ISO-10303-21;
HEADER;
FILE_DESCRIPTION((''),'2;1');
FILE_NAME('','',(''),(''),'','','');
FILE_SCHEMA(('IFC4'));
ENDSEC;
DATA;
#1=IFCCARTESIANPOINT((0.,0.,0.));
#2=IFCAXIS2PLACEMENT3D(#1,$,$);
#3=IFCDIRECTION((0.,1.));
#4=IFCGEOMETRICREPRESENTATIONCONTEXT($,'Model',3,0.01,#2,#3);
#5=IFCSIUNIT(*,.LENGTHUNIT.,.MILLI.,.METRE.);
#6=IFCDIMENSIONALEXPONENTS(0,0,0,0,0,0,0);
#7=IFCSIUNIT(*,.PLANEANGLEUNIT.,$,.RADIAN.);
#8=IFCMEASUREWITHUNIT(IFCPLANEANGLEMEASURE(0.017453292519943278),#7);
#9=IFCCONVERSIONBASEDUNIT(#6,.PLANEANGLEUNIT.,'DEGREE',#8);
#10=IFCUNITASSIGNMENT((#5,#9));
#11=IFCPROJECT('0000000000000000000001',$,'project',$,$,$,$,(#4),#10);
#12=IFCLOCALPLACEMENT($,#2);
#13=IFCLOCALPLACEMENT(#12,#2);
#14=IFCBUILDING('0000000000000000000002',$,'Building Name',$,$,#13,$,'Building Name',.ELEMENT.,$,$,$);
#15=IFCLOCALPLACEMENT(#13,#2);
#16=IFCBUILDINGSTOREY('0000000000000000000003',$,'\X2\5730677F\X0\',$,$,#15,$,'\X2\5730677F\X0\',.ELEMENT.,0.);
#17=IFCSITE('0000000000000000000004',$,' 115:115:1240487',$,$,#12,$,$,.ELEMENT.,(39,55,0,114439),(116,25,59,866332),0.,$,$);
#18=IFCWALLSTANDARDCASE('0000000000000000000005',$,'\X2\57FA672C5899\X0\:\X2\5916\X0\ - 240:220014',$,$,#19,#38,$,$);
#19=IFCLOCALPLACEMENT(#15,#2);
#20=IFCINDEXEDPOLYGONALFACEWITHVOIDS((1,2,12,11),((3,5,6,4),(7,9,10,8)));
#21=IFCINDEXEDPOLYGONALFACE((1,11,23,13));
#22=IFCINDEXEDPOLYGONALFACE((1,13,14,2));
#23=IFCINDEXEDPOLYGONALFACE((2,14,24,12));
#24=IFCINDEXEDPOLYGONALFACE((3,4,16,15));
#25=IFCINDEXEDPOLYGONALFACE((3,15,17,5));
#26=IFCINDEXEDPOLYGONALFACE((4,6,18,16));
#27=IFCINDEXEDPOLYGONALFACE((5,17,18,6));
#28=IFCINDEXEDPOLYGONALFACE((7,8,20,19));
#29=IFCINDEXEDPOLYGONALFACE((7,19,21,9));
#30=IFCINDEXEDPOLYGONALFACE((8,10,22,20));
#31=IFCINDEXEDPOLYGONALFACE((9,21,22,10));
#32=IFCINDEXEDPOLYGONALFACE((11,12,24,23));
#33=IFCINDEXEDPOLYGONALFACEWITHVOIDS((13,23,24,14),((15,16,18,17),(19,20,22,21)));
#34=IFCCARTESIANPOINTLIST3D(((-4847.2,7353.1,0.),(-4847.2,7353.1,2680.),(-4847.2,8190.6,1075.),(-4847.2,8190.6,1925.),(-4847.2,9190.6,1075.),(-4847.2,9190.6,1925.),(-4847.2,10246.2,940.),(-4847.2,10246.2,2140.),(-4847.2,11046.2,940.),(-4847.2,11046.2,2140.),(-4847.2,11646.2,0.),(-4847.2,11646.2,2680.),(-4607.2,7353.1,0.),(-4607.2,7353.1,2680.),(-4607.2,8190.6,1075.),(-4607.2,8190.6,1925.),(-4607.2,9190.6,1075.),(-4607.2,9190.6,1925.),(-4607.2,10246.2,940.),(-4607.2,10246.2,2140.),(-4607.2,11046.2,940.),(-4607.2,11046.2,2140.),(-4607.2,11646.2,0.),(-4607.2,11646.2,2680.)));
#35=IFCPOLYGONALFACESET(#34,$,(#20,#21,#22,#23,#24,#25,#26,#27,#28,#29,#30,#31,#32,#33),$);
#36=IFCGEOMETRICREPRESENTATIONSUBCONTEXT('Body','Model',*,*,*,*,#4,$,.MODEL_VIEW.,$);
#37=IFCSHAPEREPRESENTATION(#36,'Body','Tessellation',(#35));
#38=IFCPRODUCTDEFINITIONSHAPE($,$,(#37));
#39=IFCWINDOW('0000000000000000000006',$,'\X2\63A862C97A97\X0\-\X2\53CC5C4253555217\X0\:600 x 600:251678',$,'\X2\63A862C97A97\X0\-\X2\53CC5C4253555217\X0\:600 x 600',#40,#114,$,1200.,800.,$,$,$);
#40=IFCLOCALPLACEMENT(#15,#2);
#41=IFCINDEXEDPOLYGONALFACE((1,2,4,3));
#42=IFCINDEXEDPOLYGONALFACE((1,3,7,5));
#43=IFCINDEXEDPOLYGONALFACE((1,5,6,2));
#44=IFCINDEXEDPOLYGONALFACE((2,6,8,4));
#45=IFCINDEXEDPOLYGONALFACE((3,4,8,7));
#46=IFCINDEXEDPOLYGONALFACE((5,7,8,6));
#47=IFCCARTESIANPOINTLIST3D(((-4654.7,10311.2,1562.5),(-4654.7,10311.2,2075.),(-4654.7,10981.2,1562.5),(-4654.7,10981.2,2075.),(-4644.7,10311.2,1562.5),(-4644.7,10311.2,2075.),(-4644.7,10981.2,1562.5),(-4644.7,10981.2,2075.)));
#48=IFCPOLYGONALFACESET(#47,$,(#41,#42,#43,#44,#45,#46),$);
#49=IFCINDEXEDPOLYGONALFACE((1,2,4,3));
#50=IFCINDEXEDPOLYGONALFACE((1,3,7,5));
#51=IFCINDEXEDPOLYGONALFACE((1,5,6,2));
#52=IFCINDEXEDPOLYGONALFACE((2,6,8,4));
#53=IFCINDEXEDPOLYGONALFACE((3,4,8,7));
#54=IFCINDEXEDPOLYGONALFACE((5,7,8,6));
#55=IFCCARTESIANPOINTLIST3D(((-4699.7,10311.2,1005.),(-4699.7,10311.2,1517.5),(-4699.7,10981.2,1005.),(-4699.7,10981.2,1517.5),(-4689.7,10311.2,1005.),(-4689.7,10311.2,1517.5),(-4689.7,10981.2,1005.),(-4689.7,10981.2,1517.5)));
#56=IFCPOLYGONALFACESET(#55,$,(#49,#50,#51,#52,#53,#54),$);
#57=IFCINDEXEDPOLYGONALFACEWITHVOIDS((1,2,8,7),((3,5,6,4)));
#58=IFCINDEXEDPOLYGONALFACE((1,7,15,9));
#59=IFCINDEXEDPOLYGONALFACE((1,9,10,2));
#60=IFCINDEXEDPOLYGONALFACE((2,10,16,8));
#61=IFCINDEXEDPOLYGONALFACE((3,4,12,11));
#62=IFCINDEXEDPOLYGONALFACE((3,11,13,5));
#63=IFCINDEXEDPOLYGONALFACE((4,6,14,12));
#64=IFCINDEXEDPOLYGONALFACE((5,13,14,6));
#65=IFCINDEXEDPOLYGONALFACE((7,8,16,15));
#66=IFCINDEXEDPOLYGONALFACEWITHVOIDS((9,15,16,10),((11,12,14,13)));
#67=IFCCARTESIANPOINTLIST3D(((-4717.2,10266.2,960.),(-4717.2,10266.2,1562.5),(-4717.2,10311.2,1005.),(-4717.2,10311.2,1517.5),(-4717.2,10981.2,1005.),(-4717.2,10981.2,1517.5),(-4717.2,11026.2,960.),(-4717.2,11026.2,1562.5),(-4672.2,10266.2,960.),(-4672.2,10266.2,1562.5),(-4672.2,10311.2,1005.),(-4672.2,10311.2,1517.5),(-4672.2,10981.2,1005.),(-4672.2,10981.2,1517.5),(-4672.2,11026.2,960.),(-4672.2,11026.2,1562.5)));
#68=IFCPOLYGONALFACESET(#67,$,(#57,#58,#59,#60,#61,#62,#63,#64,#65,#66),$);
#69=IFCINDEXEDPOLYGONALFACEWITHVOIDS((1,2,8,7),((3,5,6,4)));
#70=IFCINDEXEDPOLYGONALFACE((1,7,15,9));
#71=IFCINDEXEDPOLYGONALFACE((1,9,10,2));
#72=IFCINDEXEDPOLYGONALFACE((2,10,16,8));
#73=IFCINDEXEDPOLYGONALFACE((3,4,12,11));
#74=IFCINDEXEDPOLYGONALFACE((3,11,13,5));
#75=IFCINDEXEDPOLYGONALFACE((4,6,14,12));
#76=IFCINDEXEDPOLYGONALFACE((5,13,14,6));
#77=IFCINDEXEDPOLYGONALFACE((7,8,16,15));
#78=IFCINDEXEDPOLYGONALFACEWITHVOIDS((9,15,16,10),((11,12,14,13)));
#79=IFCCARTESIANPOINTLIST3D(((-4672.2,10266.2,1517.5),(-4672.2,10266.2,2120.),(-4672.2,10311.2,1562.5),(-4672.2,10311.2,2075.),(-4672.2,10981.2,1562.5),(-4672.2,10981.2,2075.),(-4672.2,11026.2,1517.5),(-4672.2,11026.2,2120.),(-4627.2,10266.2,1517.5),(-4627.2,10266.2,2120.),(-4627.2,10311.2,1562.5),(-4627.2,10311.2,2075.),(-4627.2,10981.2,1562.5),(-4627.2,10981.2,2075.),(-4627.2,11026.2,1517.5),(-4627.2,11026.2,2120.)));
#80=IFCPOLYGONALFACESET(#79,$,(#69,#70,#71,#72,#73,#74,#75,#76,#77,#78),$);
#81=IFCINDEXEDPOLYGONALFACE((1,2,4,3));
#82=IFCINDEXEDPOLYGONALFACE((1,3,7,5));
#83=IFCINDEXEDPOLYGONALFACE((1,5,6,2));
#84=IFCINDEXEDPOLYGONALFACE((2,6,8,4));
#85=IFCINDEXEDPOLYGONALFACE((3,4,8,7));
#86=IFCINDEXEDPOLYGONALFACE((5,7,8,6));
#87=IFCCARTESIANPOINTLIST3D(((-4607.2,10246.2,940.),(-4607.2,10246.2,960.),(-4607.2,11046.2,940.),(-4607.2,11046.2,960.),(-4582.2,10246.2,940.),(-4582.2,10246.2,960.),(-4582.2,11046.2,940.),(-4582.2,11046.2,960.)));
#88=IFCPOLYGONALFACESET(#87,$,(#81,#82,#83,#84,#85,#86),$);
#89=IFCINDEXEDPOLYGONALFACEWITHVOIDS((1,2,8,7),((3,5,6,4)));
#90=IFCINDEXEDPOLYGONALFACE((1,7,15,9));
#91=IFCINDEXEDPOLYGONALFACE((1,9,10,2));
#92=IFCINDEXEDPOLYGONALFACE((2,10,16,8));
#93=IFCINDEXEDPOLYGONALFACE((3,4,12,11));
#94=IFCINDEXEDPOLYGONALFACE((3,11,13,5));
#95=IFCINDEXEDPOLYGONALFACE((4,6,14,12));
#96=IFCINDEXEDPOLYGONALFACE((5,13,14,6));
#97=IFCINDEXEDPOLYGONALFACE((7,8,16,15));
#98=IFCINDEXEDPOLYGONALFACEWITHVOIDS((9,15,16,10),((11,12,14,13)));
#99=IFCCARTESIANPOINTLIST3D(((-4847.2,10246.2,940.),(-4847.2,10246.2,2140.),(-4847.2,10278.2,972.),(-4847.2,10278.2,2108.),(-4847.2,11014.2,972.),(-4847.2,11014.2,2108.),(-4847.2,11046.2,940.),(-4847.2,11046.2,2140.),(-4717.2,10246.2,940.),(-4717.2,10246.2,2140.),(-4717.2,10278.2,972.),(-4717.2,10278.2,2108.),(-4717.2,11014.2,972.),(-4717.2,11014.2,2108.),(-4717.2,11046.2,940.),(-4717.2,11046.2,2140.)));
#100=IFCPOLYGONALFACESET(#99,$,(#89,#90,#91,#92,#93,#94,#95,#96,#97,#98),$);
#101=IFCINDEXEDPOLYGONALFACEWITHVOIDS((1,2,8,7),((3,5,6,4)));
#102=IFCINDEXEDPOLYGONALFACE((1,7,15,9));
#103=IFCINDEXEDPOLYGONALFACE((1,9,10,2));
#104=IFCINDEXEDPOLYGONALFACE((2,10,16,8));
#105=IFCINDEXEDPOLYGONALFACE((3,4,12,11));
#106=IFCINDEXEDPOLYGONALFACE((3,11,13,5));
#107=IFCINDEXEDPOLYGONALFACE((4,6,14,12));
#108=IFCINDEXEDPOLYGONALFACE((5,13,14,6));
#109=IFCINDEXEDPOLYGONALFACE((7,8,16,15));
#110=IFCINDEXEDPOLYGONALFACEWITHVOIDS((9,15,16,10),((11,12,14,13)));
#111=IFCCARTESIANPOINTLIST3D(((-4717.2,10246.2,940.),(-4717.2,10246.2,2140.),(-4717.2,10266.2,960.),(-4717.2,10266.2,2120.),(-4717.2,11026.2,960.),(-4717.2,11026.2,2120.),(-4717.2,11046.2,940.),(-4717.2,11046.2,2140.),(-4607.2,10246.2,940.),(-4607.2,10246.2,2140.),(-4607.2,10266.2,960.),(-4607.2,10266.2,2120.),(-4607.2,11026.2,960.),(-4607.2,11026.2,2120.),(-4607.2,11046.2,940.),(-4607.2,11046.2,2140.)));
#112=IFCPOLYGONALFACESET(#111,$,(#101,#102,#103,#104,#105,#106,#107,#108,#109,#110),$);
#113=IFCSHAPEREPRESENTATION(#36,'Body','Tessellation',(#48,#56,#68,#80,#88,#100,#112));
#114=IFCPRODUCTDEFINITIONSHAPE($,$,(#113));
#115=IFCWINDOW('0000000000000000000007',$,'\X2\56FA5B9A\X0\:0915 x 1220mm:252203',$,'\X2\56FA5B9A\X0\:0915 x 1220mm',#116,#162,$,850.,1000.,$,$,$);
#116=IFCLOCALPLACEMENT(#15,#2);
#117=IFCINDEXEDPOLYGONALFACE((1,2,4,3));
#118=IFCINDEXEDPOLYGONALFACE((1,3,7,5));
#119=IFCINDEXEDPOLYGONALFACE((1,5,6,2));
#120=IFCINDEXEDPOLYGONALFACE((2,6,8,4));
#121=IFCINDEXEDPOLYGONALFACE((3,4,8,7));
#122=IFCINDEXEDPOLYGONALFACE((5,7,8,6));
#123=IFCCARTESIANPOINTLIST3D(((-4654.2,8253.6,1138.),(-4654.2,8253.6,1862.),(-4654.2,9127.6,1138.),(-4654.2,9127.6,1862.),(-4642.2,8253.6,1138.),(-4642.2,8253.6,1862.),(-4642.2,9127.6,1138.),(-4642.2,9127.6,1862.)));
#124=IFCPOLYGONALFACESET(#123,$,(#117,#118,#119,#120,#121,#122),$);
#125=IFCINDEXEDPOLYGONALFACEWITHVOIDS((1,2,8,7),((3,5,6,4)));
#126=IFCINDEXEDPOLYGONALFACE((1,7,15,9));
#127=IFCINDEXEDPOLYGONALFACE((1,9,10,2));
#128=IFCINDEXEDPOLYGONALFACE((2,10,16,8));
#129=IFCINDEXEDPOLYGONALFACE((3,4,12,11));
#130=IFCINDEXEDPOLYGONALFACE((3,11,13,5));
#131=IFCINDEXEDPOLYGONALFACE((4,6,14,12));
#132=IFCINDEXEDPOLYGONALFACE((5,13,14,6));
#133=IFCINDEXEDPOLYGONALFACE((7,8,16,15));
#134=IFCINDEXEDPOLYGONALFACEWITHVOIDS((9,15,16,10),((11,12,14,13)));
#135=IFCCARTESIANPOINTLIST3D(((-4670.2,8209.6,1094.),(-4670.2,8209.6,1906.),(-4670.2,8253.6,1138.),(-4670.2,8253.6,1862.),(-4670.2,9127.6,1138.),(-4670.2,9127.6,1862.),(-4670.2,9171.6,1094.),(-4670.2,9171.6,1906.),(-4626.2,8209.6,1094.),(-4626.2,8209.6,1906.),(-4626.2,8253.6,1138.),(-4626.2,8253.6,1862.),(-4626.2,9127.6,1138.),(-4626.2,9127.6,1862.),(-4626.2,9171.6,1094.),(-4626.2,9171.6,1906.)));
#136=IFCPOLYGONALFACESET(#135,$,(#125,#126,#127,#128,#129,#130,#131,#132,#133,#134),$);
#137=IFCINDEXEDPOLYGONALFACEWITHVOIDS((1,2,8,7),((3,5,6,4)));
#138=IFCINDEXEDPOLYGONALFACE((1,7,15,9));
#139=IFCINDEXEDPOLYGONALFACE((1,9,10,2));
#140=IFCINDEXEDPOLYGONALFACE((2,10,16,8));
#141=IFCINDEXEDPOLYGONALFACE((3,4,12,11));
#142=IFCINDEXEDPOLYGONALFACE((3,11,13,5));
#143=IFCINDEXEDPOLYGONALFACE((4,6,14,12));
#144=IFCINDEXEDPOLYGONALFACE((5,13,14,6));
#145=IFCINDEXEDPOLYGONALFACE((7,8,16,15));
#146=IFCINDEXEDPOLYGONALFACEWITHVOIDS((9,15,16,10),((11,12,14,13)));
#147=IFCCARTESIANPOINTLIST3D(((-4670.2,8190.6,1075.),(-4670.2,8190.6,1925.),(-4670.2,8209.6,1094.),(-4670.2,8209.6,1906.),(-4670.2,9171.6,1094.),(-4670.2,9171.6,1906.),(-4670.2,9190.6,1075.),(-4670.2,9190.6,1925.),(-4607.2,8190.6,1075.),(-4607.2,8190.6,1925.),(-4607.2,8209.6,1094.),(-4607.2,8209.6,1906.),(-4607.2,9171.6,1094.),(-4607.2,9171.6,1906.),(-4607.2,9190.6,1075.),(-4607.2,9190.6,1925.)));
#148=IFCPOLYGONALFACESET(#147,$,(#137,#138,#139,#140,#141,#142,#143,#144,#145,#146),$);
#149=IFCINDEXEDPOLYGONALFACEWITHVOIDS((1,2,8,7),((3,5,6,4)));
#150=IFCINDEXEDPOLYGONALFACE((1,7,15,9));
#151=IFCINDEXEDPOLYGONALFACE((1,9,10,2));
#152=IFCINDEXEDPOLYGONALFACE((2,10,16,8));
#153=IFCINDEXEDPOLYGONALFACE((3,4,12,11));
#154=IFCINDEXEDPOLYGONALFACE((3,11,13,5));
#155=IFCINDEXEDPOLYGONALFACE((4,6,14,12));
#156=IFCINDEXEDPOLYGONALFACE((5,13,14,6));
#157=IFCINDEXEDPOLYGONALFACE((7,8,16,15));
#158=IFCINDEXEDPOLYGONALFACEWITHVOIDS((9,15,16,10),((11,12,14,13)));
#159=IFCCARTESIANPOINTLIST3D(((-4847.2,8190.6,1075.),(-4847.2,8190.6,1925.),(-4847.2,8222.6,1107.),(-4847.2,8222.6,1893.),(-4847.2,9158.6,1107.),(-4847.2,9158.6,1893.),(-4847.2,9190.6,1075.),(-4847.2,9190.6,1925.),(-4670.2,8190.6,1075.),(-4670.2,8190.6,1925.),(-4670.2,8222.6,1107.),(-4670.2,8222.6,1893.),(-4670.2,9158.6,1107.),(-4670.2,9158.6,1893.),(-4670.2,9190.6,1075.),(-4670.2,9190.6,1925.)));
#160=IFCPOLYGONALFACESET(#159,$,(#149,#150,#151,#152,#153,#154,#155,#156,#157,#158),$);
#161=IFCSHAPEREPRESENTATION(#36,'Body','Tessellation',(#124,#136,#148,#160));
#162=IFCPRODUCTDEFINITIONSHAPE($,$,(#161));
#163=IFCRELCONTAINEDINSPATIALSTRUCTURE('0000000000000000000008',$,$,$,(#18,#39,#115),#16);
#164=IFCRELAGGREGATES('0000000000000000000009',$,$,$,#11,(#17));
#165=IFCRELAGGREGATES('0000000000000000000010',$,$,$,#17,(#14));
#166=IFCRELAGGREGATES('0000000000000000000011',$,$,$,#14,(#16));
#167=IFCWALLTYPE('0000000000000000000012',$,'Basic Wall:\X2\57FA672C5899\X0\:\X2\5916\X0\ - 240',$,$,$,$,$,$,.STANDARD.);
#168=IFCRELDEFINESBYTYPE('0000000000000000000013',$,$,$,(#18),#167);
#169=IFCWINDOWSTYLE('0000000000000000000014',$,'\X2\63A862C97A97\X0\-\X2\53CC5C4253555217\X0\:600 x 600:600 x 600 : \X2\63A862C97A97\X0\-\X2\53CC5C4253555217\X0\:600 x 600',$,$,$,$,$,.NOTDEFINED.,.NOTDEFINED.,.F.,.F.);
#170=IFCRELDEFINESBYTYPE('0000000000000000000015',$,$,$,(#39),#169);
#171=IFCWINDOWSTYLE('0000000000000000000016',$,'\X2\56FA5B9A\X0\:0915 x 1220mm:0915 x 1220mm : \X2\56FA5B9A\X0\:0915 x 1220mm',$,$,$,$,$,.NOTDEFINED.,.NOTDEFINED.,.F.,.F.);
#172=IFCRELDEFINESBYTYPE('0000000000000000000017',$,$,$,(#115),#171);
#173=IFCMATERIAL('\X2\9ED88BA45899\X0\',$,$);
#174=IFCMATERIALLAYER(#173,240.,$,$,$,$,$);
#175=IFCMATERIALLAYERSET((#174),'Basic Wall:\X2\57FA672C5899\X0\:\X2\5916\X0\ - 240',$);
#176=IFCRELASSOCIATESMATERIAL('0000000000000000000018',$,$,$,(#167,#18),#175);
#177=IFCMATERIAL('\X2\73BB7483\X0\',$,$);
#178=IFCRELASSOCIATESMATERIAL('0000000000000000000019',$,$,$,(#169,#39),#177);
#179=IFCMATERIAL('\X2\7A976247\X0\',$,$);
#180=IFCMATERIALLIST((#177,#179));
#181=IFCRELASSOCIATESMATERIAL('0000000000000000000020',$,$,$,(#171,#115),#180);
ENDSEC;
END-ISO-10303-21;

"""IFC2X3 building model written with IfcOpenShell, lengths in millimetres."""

from ifc_helpers import new_model, entity, si_unit, converted_unit, direction, frame, frame_2d, origin, origin_2d_with_axis, place, context, subcontext, project, spatial, polyline, rectangle, outline, extrude, source, transform, mapped, material, material_list, layer, layer_set, layer_usage, type_object, type_shapes, element, fill, save


model = new_model("IFC2X3")

# Units and contexts
model_context = context("Model", 3, precision=0.01, world=origin(), true_north=direction((0.0, 1.0)))
body_context = subcontext(model_context, "Body", "Model", "MODEL_VIEW")
ifc_project = project(units=[si_unit("LENGTHUNIT", "METRE", prefix="MILLI"), converted_unit("PLANEANGLEUNIT", "DEGREE", entity("IfcPlaneAngleMeasure", 0.017453292519943278), si_unit("PLANEANGLEUNIT", "RADIAN"), dimensions=[0, 0, 0, 0, 0, 0, 0])], contexts=[model_context])

# Site, building, storey
site_placement = place(None, origin())
site = spatial("IfcSite", under=ifc_project, at=site_placement, Name=" 115:115:1240487", CompositionType="ELEMENT", RefLatitude=(39, 55, 0, 114439), RefLongitude=(116, 25, 59, 866332), RefElevation=0.0)
building_placement = place(site_placement, origin())
building = spatial("IfcBuilding", under=site, at=building_placement, Name="Building Name", LongName="Building Name", CompositionType="ELEMENT")
storey_placement = place(building_placement, origin())
storey = spatial("IfcBuildingStorey", under=building, at=storey_placement, Name="地板", LongName="地板", CompositionType="ELEMENT", Elevation=0.0)

# Shared definitions
ifc_material_1 = material(Name="默认墙")
ifc_layer_1 = layer(ifc_material_1, 240.0)
ifc_layer_set_1 = layer_set([ifc_layer_1], Name="Basic Wall:基本墙:外 - 240")
wall_type_1 = type_object("IfcWallType", Name="Basic Wall:基本墙:外 - 240", PredefinedType="STANDARD", material=ifc_layer_set_1)
ifc_material_2 = material(Name="玻璃")
ifc_material_3 = material(Name="窗扇")
ifc_material_list_1 = material_list([ifc_material_2, ifc_material_3])

# Wall, openings, windows
ifc_layer_usage_1 = layer_usage(ifc_layer_set_1, "AXIS2", "NEGATIVE", 120.0)
wall_1_placement = place(storey_placement, frame((-4727.2, 7353.1, 0.0), z_axis=(0.0, 0.0, 1.0), x_axis=(0.0, 1.0, 0.0)))
wall_1 = element("IfcWallStandardCase", 1, at=wall_1_placement, inside=storey, type_object=wall_type_1, material=ifc_layer_usage_1, Name="基本墙:外 - 240:220014", context=body_context, shape_type="SweptSolid", body=[
    extrude(rectangle(XDim=4293.1, YDim=240.0, at=frame_2d((2146.5, 0.0), x_axis=(-1.0, 0.0))), origin(), (0.0, 0.0, 1.0), 2680.0),
])
opening_1_placement = place(wall_1_placement, frame((-7353.1, -4727.2, 0.0), z_axis=(0.0, 0.0, 1.0), x_axis=(0.0, -1.0, 0.0)))
opening_1 = element("IfcOpeningElement", 2, at=opening_1_placement, cuts=wall_1, ObjectType="Opening", context=body_context, shape_type="SweptSolid", body=[
    extrude(rectangle(XDim=1200.0, YDim=800.0, at=frame_2d((0.0, 0.0), x_axis=(1.0, 0.0))), frame((-4604.8, 10646.2, 1540.0), z_axis=(-1.0, 0.0, 0.0), x_axis=(0.0, 0.0, 1.0)), (0.0, 0.0, 1.0), 244.8),
])
opening_2_placement = place(wall_1_placement, frame((-7353.1, -4727.2, 0.0), z_axis=(0.0, 0.0, 1.0), x_axis=(0.0, -1.0, 0.0)))
opening_2 = element("IfcOpeningElement", 3, at=opening_2_placement, cuts=wall_1, ObjectType="Opening", context=body_context, shape_type="SweptSolid", body=[
    extrude(rectangle(XDim=850.0, YDim=1000.0, at=origin_2d_with_axis()), frame((-4604.8, 8690.6, 1500.0), z_axis=(-1.0, 0.0, 0.0), x_axis=(0.0, 0.0, -1.0)), (0.0, 0.0, 1.0), 244.8),
])
window_style_1 = type_object("IfcWindowStyle", Name="推拉窗-双层单列:600 x 600:600 x 600 : 推拉窗-双层单列:600 x 600", ConstructionType="NOTDEFINED", OperationType="NOTDEFINED", ParameterTakesPrecedence=False, Sizeable=False, material=ifc_material_2)
shared_shape_1 = source(origin(), body_context, "Body", "SweptSolid", [
    extrude(rectangle(XDim=670.0, YDim=10.0, at=origin_2d_with_axis()), frame((400.0, 199.9, 622.5)), (0.0, 0.0, 1.0), 512.5),
    extrude(rectangle(XDim=670.0, YDim=10.0, at=origin_2d_with_axis()), frame((400.0, 154.9, 65.0)), (0.0, 0.0, 1.0), 512.5),
    extrude(outline(polyline([(-301.2, -380.0), (301.2, -380.0), (301.2, 380.0), (-301.2, 380.0), (-301.2, -380.0)]), holes=[polyline([(256.2, 335.0), (256.3, -335.0), (-256.2, -335.0), (-256.2, 335.0), (256.2, 335.0)])]), frame((400.0, 132.4, 321.3), z_axis=(0.0, 1.0, 0.0), x_axis=(0.0, 0.0, -1.0)), (0.0, 0.0, 1.0), 45.0),
    extrude(outline(polyline([(-301.2, -380.0), (301.2, -380.0), (301.2, 380.0), (-301.2, 380.0), (-301.2, -380.0)]), holes=[polyline([(256.2, 335.0), (256.2, -335.0), (-256.2, -335.0), (-256.2, 335.0), (256.2, 335.0)])]), frame((400.0, 177.4, 878.8), z_axis=(0.0, 1.0, 0.0), x_axis=(0.0, 0.0, -1.0)), (0.0, 0.0, 1.0), 45.0),
    extrude(rectangle(XDim=800.0, YDim=25.0, at=origin_2d_with_axis()), frame((400.0, 254.9, 0.0)), (0.0, 0.0, 1.0), 20.0),
    extrude(outline(polyline([(-600.0, -400.0), (600.0, -400.0), (600.0, 400.0), (-600.0, 400.0), (-600.0, -400.0)]), holes=[polyline([(568.0, 368.0), (568.0, -368.0), (-568.0, -368.0), (-568.0, 368.0), (568.0, 368.0)])]), frame((400.0, 2.4, 600.0), z_axis=(0.0, 1.0, 0.0), x_axis=(0.0, 0.0, -1.0)), (0.0, 0.0, 1.0), 130.0),
    extrude(outline(polyline([(-400.0, -600.0), (400.0, -600.0), (400.0, 600.0), (-400.0, 600.0), (-400.0, -600.0)]), holes=[polyline([(380.0, 580.0), (380.0, -580.0), (-380.0, -580.0), (-380.0, 580.0), (380.0, 580.0)])]), frame((400.0, 132.4, 600.0), z_axis=(0.0, 1.0, 0.0), x_axis=(-1.0, 0.0, 0.0)), (0.0, 0.0, 1.0), 110.0),
])
type_shapes(window_style_1, [shared_shape_1])
window_1_placement = place(opening_1_placement, frame((-4849.6, 11046.2, 940.0), z_axis=(0.0, 0.0, 1.0), x_axis=(0.0, -1.0, 0.0)))
window_1 = element("IfcWindow", 4, at=window_1_placement, inside=storey, type_object=window_style_1, material=ifc_material_2, Name="推拉窗-双层单列:600 x 600:251678", ObjectType="推拉窗-双层单列:600 x 600", OverallHeight=1200.0, OverallWidth=800.0, context=body_context, shape_type="MappedRepresentation", body=[
    mapped(shared_shape_1, transform((0.0, 0.0, 0.0), scale=1.0)),
])
fill(opening_1, window_1)
window_style_2 = type_object("IfcWindowStyle", Name="固定:0915 x 1220mm:0915 x 1220mm : 固定:0915 x 1220mm", ConstructionType="NOTDEFINED", OperationType="NOTDEFINED", ParameterTakesPrecedence=False, Sizeable=False, material=ifc_material_list_1)
shared_shape_2 = source(origin(), body_context, "Body", "SweptSolid", [
    extrude(rectangle(XDim=874.0, YDim=12.0, at=origin_2d_with_axis()), frame((500.0, 201.4, 63.0)), (0.0, 0.0, 1.0), 724.0),
    extrude(outline(polyline([(-406.0, -481.0), (406.0, -481.0), (406.0, 481.0), (-406.0, 481.0), (-406.0, -481.0)]), holes=[polyline([(362.0, 437.0), (362.0, -437.0), (-362.0, -437.0), (-362.0, 437.0), (362.0, 437.0)])]), frame((500.0, 179.4, 425.0), z_axis=(0.0, 1.0, 0.0), x_axis=(0.0, 0.0, -1.0)), (0.0, 0.0, 1.0), 44.0),
    extrude(outline(polyline([(-425.0, -500.0), (425.0, -500.0), (425.0, 500.0), (-425.0, 500.0), (-425.0, -500.0)]), holes=[polyline([(406.0, 481.0), (406.0, -481.0), (-406.0, -481.0), (-406.0, 481.0), (406.0, 481.0)])]), frame((500.0, 179.4, 425.0), z_axis=(0.0, 1.0, 0.0), x_axis=(0.0, 0.0, -1.0)), (0.0, 0.0, 1.0), 63.0),
    extrude(outline(polyline([(-425.0, -500.0), (425.0, -500.0), (425.0, 500.0), (-425.0, 500.0), (-425.0, -500.0)]), holes=[polyline([(393.0, 468.0), (393.0, -468.0), (-393.0, -468.0), (-393.0, 468.0), (393.0, 468.0)])]), frame((500.0, 2.4, 425.0), z_axis=(0.0, 1.0, 0.0), x_axis=(0.0, 0.0, -1.0)), (0.0, 0.0, 1.0), 177.0),
])
type_shapes(window_style_2, [shared_shape_2])
window_2_placement = place(opening_2_placement, frame((-4849.6, 9190.6, 1075.0), z_axis=(0.0, 0.0, 1.0), x_axis=(0.0, -1.0, 0.0)))
window_2 = element("IfcWindow", 5, at=window_2_placement, inside=storey, type_object=window_style_2, material=ifc_material_list_1, Name="固定:0915 x 1220mm:252203", ObjectType="固定:0915 x 1220mm", OverallHeight=850.0, OverallWidth=1000.0, context=body_context, shape_type="MappedRepresentation", body=[
    mapped(shared_shape_2, transform((0.0, 0.0, 0.0), scale=1.0)),
])
fill(opening_2, window_2)

save(model, "model.ifc")
